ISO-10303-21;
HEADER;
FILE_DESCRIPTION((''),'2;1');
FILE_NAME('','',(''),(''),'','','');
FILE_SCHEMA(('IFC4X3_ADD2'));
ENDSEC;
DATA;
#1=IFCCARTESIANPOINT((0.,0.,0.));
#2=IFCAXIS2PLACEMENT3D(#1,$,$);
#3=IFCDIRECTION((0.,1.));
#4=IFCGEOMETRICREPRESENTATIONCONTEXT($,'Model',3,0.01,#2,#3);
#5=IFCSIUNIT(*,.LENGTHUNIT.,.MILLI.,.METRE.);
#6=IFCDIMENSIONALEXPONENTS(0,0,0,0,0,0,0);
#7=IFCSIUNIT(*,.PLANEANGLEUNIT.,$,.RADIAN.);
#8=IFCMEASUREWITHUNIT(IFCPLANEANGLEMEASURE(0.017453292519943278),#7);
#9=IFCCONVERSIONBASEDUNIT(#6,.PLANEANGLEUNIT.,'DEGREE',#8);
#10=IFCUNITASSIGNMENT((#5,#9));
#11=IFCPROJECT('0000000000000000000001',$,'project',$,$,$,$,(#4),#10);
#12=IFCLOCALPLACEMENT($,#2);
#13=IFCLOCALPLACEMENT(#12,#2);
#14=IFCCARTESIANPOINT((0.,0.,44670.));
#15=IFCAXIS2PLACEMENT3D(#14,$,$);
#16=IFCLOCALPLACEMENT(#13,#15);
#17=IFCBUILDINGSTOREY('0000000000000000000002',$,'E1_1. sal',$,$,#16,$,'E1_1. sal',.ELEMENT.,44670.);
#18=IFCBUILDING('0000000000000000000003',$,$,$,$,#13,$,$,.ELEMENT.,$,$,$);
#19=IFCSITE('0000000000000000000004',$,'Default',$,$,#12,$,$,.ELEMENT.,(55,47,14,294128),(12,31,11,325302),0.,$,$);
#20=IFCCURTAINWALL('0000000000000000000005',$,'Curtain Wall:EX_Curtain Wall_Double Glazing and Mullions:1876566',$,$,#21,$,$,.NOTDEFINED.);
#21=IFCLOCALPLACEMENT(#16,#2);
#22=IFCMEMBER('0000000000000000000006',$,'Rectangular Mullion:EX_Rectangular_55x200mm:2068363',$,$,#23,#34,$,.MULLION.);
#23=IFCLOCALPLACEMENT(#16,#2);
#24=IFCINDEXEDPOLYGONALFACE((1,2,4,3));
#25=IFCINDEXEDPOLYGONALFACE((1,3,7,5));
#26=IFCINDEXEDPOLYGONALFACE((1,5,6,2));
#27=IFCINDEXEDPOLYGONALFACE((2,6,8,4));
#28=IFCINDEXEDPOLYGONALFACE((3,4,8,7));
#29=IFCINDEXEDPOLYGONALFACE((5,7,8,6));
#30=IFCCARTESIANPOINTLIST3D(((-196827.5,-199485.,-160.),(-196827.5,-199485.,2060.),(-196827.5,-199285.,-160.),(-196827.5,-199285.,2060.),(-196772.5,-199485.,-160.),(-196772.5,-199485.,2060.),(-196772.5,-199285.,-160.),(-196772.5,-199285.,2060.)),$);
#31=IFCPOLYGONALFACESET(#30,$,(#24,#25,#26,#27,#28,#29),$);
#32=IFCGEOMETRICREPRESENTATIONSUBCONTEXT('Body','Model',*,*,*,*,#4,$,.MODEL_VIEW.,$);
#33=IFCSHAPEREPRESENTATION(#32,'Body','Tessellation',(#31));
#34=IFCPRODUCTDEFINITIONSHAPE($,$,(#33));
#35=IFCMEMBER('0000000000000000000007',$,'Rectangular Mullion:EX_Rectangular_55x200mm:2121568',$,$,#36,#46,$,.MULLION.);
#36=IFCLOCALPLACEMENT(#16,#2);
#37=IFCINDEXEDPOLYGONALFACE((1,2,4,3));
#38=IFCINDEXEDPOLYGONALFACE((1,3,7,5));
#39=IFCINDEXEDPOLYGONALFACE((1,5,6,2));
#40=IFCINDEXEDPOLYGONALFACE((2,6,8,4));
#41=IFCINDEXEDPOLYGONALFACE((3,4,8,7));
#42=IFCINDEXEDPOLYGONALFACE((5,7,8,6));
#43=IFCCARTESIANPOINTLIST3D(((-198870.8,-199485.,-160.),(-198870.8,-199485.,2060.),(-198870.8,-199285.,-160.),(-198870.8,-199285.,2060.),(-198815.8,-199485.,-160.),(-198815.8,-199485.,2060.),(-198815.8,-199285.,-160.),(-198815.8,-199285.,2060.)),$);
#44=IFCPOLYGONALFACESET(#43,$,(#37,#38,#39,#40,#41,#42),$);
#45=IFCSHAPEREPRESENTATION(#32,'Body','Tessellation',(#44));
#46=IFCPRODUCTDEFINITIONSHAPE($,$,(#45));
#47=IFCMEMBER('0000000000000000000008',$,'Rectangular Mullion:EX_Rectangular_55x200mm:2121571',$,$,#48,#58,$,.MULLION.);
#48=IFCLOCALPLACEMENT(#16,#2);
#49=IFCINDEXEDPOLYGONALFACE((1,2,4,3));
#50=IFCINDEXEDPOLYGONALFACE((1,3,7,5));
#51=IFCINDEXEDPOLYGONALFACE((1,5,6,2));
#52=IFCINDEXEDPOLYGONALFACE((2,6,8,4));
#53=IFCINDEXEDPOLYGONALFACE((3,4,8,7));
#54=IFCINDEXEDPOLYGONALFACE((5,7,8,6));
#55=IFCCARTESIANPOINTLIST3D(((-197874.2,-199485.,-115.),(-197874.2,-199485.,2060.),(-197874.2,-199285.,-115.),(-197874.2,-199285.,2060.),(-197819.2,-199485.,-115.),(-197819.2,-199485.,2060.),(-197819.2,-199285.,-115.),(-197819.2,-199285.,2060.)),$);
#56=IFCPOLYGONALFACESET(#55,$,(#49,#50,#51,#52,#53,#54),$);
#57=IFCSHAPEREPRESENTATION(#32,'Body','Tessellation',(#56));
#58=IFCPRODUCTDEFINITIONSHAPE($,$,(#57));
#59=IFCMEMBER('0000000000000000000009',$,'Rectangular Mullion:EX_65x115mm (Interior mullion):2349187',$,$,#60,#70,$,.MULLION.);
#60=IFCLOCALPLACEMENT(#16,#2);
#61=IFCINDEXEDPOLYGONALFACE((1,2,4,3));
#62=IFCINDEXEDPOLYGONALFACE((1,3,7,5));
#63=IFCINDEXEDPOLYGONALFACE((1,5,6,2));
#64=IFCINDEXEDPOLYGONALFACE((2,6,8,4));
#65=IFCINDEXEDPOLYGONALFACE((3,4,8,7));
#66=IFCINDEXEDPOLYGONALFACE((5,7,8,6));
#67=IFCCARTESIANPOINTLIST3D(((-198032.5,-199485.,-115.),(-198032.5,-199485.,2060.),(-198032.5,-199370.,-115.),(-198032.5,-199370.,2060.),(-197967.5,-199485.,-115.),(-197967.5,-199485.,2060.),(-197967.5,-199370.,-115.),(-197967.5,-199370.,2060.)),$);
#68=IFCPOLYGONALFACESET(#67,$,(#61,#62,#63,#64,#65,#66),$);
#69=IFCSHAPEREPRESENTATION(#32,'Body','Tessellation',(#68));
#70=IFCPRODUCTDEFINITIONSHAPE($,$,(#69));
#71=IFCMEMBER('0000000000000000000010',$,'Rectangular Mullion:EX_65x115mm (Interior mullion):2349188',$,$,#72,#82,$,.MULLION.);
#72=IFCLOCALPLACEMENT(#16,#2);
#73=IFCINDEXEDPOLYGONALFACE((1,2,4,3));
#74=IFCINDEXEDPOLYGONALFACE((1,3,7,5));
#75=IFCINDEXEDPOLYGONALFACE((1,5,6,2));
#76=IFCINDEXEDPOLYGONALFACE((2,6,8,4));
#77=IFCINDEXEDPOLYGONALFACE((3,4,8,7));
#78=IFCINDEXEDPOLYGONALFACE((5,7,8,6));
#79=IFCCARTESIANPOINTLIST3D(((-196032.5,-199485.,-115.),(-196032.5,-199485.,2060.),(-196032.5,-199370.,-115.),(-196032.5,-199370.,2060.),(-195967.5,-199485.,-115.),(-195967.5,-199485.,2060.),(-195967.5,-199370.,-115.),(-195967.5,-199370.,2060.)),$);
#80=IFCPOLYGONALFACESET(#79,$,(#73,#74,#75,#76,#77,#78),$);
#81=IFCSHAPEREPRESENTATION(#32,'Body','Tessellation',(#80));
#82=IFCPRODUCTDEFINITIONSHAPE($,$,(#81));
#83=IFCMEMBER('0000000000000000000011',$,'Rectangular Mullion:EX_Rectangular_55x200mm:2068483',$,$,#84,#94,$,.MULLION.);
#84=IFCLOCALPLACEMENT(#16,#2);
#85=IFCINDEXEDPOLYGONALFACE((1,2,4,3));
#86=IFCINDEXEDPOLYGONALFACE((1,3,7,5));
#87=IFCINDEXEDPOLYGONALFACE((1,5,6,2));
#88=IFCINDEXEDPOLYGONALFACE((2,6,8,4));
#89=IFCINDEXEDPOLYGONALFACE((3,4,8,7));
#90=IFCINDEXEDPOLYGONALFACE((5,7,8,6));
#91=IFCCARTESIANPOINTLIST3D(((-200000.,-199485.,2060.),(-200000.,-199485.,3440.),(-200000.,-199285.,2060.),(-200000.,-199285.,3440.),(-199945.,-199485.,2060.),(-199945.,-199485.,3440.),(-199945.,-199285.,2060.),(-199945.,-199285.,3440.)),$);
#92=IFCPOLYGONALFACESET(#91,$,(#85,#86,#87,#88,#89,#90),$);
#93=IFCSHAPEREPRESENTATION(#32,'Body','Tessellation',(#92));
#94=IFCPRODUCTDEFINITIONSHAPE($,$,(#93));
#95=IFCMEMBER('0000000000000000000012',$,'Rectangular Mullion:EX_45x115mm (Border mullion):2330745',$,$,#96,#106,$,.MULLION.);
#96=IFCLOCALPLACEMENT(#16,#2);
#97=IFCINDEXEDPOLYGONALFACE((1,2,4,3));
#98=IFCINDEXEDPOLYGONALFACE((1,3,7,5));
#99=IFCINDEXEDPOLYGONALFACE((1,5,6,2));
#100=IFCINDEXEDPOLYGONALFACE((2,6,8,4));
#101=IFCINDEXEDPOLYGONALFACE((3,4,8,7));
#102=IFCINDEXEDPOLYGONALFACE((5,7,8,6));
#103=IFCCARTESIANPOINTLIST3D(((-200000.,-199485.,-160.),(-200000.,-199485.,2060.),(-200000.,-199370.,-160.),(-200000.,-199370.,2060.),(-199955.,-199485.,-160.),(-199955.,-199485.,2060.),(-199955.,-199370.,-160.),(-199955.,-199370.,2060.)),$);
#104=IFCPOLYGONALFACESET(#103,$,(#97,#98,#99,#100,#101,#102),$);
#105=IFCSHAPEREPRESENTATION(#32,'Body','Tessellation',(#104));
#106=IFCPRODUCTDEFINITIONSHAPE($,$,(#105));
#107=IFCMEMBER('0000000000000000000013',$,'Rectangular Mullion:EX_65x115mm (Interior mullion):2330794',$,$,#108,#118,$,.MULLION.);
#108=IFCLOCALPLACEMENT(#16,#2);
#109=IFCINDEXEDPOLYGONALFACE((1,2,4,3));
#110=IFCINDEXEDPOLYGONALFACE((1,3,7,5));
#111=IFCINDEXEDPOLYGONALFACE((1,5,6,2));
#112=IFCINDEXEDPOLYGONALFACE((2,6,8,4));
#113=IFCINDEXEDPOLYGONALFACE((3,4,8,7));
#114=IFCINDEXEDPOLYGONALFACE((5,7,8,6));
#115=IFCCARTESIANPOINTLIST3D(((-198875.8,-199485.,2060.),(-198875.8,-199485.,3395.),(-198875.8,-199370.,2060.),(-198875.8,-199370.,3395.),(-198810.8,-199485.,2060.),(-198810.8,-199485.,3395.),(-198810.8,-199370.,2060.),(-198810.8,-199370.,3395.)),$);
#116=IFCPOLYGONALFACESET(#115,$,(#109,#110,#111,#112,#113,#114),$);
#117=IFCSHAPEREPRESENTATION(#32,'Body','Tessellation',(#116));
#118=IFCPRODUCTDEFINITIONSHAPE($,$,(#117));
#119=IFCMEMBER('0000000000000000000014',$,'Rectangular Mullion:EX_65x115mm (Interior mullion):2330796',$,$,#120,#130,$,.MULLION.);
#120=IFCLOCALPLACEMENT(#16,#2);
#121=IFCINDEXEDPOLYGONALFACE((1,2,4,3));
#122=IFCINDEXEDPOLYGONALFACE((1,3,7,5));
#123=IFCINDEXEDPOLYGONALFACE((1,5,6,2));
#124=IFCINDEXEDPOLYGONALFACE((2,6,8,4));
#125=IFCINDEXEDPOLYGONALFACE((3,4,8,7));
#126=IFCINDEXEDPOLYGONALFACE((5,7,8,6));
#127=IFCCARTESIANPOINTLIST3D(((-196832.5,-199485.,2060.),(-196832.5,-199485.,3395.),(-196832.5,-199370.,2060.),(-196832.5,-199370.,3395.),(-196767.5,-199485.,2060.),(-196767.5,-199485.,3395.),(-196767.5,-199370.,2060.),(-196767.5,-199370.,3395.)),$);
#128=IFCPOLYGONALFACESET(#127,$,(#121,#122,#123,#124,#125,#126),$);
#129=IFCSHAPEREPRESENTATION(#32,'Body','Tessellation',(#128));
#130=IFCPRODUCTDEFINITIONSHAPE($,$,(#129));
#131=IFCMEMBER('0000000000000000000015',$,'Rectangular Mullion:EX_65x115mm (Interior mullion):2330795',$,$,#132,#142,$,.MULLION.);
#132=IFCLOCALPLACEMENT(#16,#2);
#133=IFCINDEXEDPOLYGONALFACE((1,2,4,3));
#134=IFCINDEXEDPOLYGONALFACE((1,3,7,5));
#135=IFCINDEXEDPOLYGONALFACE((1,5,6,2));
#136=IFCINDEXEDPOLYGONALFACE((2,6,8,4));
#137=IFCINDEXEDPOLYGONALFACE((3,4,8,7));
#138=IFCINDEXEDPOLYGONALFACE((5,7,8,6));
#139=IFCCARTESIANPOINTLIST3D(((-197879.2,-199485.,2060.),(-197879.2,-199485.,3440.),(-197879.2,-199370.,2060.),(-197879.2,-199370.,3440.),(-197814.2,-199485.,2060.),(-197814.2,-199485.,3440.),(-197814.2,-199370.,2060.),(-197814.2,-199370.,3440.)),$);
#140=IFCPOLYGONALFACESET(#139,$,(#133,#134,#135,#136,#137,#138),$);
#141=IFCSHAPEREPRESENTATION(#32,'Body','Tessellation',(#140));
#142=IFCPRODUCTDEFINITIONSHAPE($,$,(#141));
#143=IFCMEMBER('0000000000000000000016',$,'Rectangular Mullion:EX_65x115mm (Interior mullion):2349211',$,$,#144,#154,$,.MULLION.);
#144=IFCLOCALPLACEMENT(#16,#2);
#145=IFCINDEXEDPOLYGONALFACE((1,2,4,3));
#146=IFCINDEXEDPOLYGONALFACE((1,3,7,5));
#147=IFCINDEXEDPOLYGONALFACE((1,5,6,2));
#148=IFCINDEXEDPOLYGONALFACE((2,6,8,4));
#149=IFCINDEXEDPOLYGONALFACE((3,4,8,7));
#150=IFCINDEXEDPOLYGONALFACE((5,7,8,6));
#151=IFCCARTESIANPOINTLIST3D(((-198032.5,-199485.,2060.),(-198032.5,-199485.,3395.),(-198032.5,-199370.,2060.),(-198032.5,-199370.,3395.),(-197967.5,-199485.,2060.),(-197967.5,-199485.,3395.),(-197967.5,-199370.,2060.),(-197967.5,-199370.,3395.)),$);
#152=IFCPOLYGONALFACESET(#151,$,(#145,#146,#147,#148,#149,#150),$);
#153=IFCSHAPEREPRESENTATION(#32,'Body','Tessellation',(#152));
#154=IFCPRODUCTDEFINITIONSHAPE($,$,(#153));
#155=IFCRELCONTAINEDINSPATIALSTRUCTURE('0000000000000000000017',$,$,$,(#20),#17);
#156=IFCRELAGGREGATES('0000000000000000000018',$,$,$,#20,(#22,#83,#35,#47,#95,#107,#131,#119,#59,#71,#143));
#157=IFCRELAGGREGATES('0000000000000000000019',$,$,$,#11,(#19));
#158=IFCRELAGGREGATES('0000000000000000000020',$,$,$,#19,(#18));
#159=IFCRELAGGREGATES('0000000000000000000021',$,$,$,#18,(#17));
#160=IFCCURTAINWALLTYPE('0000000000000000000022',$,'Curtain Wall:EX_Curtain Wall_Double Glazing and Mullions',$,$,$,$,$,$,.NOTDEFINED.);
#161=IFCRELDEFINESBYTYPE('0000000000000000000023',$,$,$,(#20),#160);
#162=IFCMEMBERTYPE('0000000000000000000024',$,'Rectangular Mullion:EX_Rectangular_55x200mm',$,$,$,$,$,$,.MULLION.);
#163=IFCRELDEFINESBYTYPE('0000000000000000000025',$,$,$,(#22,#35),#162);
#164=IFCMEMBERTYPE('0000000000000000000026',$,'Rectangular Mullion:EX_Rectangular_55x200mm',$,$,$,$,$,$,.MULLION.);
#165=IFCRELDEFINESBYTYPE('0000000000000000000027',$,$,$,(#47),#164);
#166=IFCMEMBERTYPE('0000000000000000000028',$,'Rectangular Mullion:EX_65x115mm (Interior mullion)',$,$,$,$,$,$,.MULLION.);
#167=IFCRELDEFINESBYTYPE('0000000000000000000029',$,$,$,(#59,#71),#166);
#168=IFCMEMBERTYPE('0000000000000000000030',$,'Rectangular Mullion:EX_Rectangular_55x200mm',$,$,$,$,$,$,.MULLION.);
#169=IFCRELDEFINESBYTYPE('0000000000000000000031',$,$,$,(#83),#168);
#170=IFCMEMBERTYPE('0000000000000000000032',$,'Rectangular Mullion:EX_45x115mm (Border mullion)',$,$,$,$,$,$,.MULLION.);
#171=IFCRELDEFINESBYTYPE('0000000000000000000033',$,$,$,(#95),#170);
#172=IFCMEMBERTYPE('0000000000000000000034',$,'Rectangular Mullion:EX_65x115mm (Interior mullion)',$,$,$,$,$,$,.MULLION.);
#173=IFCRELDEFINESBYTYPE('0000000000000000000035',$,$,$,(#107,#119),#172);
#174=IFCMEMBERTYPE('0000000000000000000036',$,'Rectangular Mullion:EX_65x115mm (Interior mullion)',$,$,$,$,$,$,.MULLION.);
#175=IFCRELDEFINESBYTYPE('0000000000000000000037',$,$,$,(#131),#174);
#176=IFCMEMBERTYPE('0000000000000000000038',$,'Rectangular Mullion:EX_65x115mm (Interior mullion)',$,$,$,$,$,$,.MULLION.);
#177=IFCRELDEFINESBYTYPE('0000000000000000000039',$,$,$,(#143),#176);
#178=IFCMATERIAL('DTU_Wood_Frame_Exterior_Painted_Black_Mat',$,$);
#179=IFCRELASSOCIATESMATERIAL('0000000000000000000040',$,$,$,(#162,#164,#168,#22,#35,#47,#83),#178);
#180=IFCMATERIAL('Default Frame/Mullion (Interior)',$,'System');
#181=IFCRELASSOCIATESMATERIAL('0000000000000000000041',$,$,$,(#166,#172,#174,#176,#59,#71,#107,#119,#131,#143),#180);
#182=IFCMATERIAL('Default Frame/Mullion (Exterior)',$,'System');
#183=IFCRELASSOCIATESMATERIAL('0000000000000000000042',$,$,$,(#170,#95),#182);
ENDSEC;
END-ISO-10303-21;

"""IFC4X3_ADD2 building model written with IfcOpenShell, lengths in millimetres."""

from ifc_helpers import new_model, entity, si_unit, converted_unit, direction, frame, origin, origin_2d_with_axis, place, context, subcontext, project, spatial, rectangle, extrude, source, transform, mapped, material, material_profile, profile_set, profile_usage, type_object, type_shapes, element, aggregate, save


model = new_model("IFC4X3_ADD2")

# Units and contexts
model_context = context("Model", 3, precision=0.01, world=origin(), true_north=direction((0.0, 1.0)))
body_context = subcontext(model_context, "Body", "Model", "MODEL_VIEW")
ifc_project = project(units=[si_unit("LENGTHUNIT", "METRE", prefix="MILLI"), converted_unit("PLANEANGLEUNIT", "DEGREE", entity("IfcPlaneAngleMeasure", 0.017453292519943278), si_unit("PLANEANGLEUNIT", "RADIAN"), dimensions=[0, 0, 0, 0, 0, 0, 0])], contexts=[model_context])

# Site, building, storey
site_placement = place(None, origin())
site = spatial("IfcSite", under=ifc_project, at=site_placement, Name="Default", CompositionType="ELEMENT", RefLatitude=(55, 47, 14, 294128), RefLongitude=(12, 31, 11, 325302), RefElevation=0.0)
building_placement = place(site_placement, origin())
building = spatial("IfcBuilding", under=site, at=building_placement, CompositionType="ELEMENT")
storey_placement = place(building_placement, frame((0.0, 0.0, 44670.0)))
storey = spatial("IfcBuildingStorey", under=building, at=storey_placement, Name="E1_1. sal", LongName="E1_1. sal", CompositionType="ELEMENT", Elevation=44670.0)

# Curtain wall, members
curtain_wall_type = type_object("IfcCurtainWallType", Name="Curtain Wall:EX_Curtain Wall_Double Glazing and Mullions", PredefinedType="NOTDEFINED")
curtain_wall_1_placement = place(storey_placement, frame((0.0, 0.0, -44670.0)))
curtain_wall_1 = element("IfcCurtainWall", 1, at=curtain_wall_1_placement, inside=storey, type_object=curtain_wall_type, Name="Curtain Wall:EX_Curtain Wall_Double Glazing and Mullions:1876566", PredefinedType="NOTDEFINED")
ifc_material_1 = material(Name="DTU_Wood_Frame_Exterior_Painted_Black_Mat")
ifc_material_profile_1 = material_profile(ifc_material_1, rectangle(XDim=55.0, YDim=200.0, at=origin_2d_with_axis()), Name="EX_Rectangular_55x200mm")
ifc_profile_set_1 = profile_set([ifc_material_profile_1], Name="EX_Rectangular_55x200mm")
ifc_profile_usage_1 = profile_usage(ifc_profile_set_1)
member_type_1 = type_object("IfcMemberType", Name="Rectangular Mullion:EX_Rectangular_55x200mm", PredefinedType="MULLION", material=ifc_profile_set_1)
shared_shape_1 = source(origin(), body_context, "Body", "SweptSolid", [
    extrude(rectangle(XDim=55.0, YDim=200.0, at=origin_2d_with_axis()), frame((0.0, -100.0, -2220.0), z_axis=(0.0, 0.0, 1.0), x_axis=(-1.0, 0.0, 0.0)), (0.0, 0.0, 1.0), 2220.0),
])
type_shapes(member_type_1, [shared_shape_1])
member_1_placement = place(curtain_wall_1_placement, frame((-196800.0, -199485.0, 44510.0), z_axis=(0.0, 0.0, -1.0), x_axis=(1.0, 0.0, 0.0)))
member_1 = element("IfcMember", 2, at=member_1_placement, type_object=member_type_1, material=ifc_profile_usage_1, Name="Rectangular Mullion:EX_Rectangular_55x200mm:2068363", PredefinedType="MULLION", context=body_context, shape_type="MappedRepresentation", body=[
    mapped(shared_shape_1, transform((0.0, 0.0, 0.0), scale=1.0)),
])
member_2_placement = place(curtain_wall_1_placement, frame((-198843.3, -199485.0, 44510.0), z_axis=(0.0, 0.0, -1.0), x_axis=(1.0, 0.0, 0.0)))
member_2 = element("IfcMember", 3, at=member_2_placement, type_object=member_type_1, material=ifc_profile_usage_1, Name="Rectangular Mullion:EX_Rectangular_55x200mm:2121568", PredefinedType="MULLION", context=body_context, shape_type="MappedRepresentation", body=[
    mapped(shared_shape_1, transform((0.0, 0.0, 0.0), scale=1.0)),
])
member_type_2 = type_object("IfcMemberType", Name="Rectangular Mullion:EX_Rectangular_55x200mm", PredefinedType="MULLION", material=ifc_profile_set_1)
shared_shape_2 = source(origin(), body_context, "Body", "SweptSolid", [
    extrude(rectangle(XDim=55.0, YDim=200.0, at=origin_2d_with_axis()), frame((0.0, -100.0, -2175.0), z_axis=(0.0, 0.0, 1.0), x_axis=(-1.0, 0.0, 0.0)), (0.0, 0.0, 1.0), 2175.0),
])
type_shapes(member_type_2, [shared_shape_2])
member_3_placement = place(curtain_wall_1_placement, frame((-197846.7, -199485.0, 44555.0), z_axis=(0.0, 0.0, -1.0), x_axis=(1.0, 0.0, 0.0)))
member_3 = element("IfcMember", 4, at=member_3_placement, type_object=member_type_2, material=ifc_profile_usage_1, Name="Rectangular Mullion:EX_Rectangular_55x200mm:2121571", PredefinedType="MULLION", context=body_context, shape_type="MappedRepresentation", body=[
    mapped(shared_shape_2, transform((0.0, 0.0, 0.0), scale=1.0)),
])
ifc_material_2 = material(Name="Default Frame/Mullion (Interior)", Category="System")
ifc_material_profile_2 = material_profile(ifc_material_2, rectangle(XDim=65.0, YDim=115.0, at=origin_2d_with_axis()), Name="EX_65x115mm (Interior mullion)")
ifc_profile_set_2 = profile_set([ifc_material_profile_2], Name="EX_65x115mm (Interior mullion)")
ifc_profile_usage_2 = profile_usage(ifc_profile_set_2)
member_type_3 = type_object("IfcMemberType", Name="Rectangular Mullion:EX_65x115mm (Interior mullion)", PredefinedType="MULLION", material=ifc_profile_set_2)
shared_shape_3 = source(origin(), body_context, "Body", "SweptSolid", [
    extrude(rectangle(XDim=65.0, YDim=115.0, at=origin_2d_with_axis()), frame((0.0, -57.5, -2175.0), z_axis=(0.0, 0.0, 1.0), x_axis=(-1.0, 0.0, 0.0)), (0.0, 0.0, 1.0), 2175.0),
])
type_shapes(member_type_3, [shared_shape_3])
member_4_placement = place(curtain_wall_1_placement, frame((-198000.0, -199485.0, 44555.0), z_axis=(0.0, 0.0, -1.0), x_axis=(1.0, 0.0, 0.0)))
member_4 = element("IfcMember", 5, at=member_4_placement, type_object=member_type_3, material=ifc_profile_usage_2, Name="Rectangular Mullion:EX_65x115mm (Interior mullion):2349187", PredefinedType="MULLION", context=body_context, shape_type="MappedRepresentation", body=[
    mapped(shared_shape_3, transform((0.0, 0.0, 0.0), scale=1.0)),
])
member_5_placement = place(curtain_wall_1_placement, frame((-196000.0, -199485.0, 44555.0), z_axis=(0.0, 0.0, -1.0), x_axis=(1.0, 0.0, 0.0)))
member_5 = element("IfcMember", 6, at=member_5_placement, type_object=member_type_3, material=ifc_profile_usage_2, Name="Rectangular Mullion:EX_65x115mm (Interior mullion):2349188", PredefinedType="MULLION", context=body_context, shape_type="MappedRepresentation", body=[
    mapped(shared_shape_3, transform((0.0, 0.0, 0.0), scale=1.0)),
])
member_type_4 = type_object("IfcMemberType", Name="Rectangular Mullion:EX_Rectangular_55x200mm", PredefinedType="MULLION", material=ifc_profile_set_1)
shared_shape_4 = source(origin(), body_context, "Body", "SweptSolid", [
    extrude(rectangle(XDim=55.0, YDim=200.0, at=origin_2d_with_axis()), frame((-27.5, -100.0, -1380.0), z_axis=(0.0, 0.0, 1.0), x_axis=(-1.0, 0.0, 0.0)), (0.0, 0.0, 1.0), 1380.0),
])
type_shapes(member_type_4, [shared_shape_4])
member_6_placement = place(curtain_wall_1_placement, frame((-200000.0, -199485.0, 48110.0), z_axis=(0.0, 0.0, 1.0), x_axis=(-1.0, 0.0, 0.0)))
member_6 = element("IfcMember", 7, at=member_6_placement, type_object=member_type_4, material=ifc_profile_usage_1, Name="Rectangular Mullion:EX_Rectangular_55x200mm:2068483", PredefinedType="MULLION", context=body_context, shape_type="MappedRepresentation", body=[
    mapped(shared_shape_4, transform((0.0, 0.0, 0.0), scale=1.0)),
])
ifc_material_3 = material(Name="Default Frame/Mullion (Exterior)", Category="System")
ifc_material_profile_3 = material_profile(ifc_material_3, rectangle(XDim=45.0, YDim=115.0, at=origin_2d_with_axis()), Name="EX_45x115mm (Border mullion)")
ifc_profile_set_3 = profile_set([ifc_material_profile_3], Name="EX_45x115mm (Border mullion)")
ifc_profile_usage_3 = profile_usage(ifc_profile_set_3)
member_type_5 = type_object("IfcMemberType", Name="Rectangular Mullion:EX_45x115mm (Border mullion)", PredefinedType="MULLION", material=ifc_profile_set_3)
shared_shape_5 = source(origin(), body_context, "Body", "SweptSolid", [
    extrude(rectangle(XDim=45.0, YDim=115.0, at=origin_2d_with_axis()), frame((-22.5, -57.5, -2220.0), z_axis=(0.0, 0.0, 1.0), x_axis=(-1.0, 0.0, 0.0)), (0.0, 0.0, 1.0), 2220.0),
])
type_shapes(member_type_5, [shared_shape_5])
member_7_placement = place(curtain_wall_1_placement, frame((-200000.0, -199485.0, 46730.0), z_axis=(0.0, 0.0, 1.0), x_axis=(-1.0, 0.0, 0.0)))
member_7 = element("IfcMember", 8, at=member_7_placement, type_object=member_type_5, material=ifc_profile_usage_3, Name="Rectangular Mullion:EX_45x115mm (Border mullion):2330745", PredefinedType="MULLION", context=body_context, shape_type="MappedRepresentation", body=[
    mapped(shared_shape_5, transform((0.0, 0.0, 0.0), scale=1.0)),
])
member_type_6 = type_object("IfcMemberType", Name="Rectangular Mullion:EX_65x115mm (Interior mullion)", PredefinedType="MULLION", material=ifc_profile_set_2)
shared_shape_6 = source(origin(), body_context, "Body", "SweptSolid", [
    extrude(rectangle(XDim=65.0, YDim=115.0, at=origin_2d_with_axis()), frame((0.0, -57.5, -1335.0), z_axis=(0.0, 0.0, 1.0), x_axis=(-1.0, 0.0, 0.0)), (0.0, 0.0, 1.0), 1335.0),
])
type_shapes(member_type_6, [shared_shape_6])
member_8_placement = place(curtain_wall_1_placement, frame((-198843.3, -199485.0, 46730.0), z_axis=(0.0, 0.0, -1.0), x_axis=(1.0, 0.0, 0.0)))
member_8 = element("IfcMember", 9, at=member_8_placement, type_object=member_type_6, material=ifc_profile_usage_2, Name="Rectangular Mullion:EX_65x115mm (Interior mullion):2330794", PredefinedType="MULLION", context=body_context, shape_type="MappedRepresentation", body=[
    mapped(shared_shape_6, transform((0.0, 0.0, 0.0), scale=1.0)),
])
member_9_placement = place(curtain_wall_1_placement, frame((-196800.0, -199485.0, 46730.0), z_axis=(0.0, 0.0, -1.0), x_axis=(1.0, 0.0, 0.0)))
member_9 = element("IfcMember", 10, at=member_9_placement, type_object=member_type_6, material=ifc_profile_usage_2, Name="Rectangular Mullion:EX_65x115mm (Interior mullion):2330796", PredefinedType="MULLION", context=body_context, shape_type="MappedRepresentation", body=[
    mapped(shared_shape_6, transform((0.0, 0.0, 0.0), scale=1.0)),
])
member_type_7 = type_object("IfcMemberType", Name="Rectangular Mullion:EX_65x115mm (Interior mullion)", PredefinedType="MULLION", material=ifc_profile_set_2)
shared_shape_7 = source(origin(), body_context, "Body", "SweptSolid", [
    extrude(rectangle(XDim=65.0, YDim=115.0, at=origin_2d_with_axis()), frame((0.0, -57.5, -1380.0), z_axis=(0.0, 0.0, 1.0), x_axis=(-1.0, 0.0, 0.0)), (0.0, 0.0, 1.0), 1380.0),
])
type_shapes(member_type_7, [shared_shape_7])
member_10_placement = place(curtain_wall_1_placement, frame((-197846.7, -199485.0, 46730.0), z_axis=(0.0, 0.0, -1.0), x_axis=(1.0, 0.0, 0.0)))
member_10 = element("IfcMember", 11, at=member_10_placement, type_object=member_type_7, material=ifc_profile_usage_2, Name="Rectangular Mullion:EX_65x115mm (Interior mullion):2330795", PredefinedType="MULLION", context=body_context, shape_type="MappedRepresentation", body=[
    mapped(shared_shape_7, transform((0.0, 0.0, 0.0), scale=1.0)),
])
member_type_8 = type_object("IfcMemberType", Name="Rectangular Mullion:EX_65x115mm (Interior mullion)", PredefinedType="MULLION", material=ifc_profile_set_2)
shared_shape_8 = source(origin(), body_context, "Body", "SweptSolid", [
    extrude(rectangle(XDim=65.0, YDim=115.0, at=origin_2d_with_axis()), frame((0.0, -57.5, -1335.0), z_axis=(0.0, 0.0, 1.0), x_axis=(-1.0, 0.0, 0.0)), (0.0, 0.0, 1.0), 1335.0),
])
type_shapes(member_type_8, [shared_shape_8])
member_11_placement = place(curtain_wall_1_placement, frame((-198000.0, -199485.0, 46730.0), z_axis=(0.0, 0.0, -1.0), x_axis=(1.0, 0.0, 0.0)))
member_11 = element("IfcMember", 12, at=member_11_placement, type_object=member_type_8, material=ifc_profile_usage_2, Name="Rectangular Mullion:EX_65x115mm (Interior mullion):2349211", PredefinedType="MULLION", context=body_context, shape_type="MappedRepresentation", body=[
    mapped(shared_shape_8, transform((0.0, 0.0, 0.0), scale=1.0)),
])
aggregate(curtain_wall_1, [member_1, member_6, member_2, member_3, member_7, member_8, member_10, member_9, member_4, member_5, member_11])

save(model, "model.ifc")
